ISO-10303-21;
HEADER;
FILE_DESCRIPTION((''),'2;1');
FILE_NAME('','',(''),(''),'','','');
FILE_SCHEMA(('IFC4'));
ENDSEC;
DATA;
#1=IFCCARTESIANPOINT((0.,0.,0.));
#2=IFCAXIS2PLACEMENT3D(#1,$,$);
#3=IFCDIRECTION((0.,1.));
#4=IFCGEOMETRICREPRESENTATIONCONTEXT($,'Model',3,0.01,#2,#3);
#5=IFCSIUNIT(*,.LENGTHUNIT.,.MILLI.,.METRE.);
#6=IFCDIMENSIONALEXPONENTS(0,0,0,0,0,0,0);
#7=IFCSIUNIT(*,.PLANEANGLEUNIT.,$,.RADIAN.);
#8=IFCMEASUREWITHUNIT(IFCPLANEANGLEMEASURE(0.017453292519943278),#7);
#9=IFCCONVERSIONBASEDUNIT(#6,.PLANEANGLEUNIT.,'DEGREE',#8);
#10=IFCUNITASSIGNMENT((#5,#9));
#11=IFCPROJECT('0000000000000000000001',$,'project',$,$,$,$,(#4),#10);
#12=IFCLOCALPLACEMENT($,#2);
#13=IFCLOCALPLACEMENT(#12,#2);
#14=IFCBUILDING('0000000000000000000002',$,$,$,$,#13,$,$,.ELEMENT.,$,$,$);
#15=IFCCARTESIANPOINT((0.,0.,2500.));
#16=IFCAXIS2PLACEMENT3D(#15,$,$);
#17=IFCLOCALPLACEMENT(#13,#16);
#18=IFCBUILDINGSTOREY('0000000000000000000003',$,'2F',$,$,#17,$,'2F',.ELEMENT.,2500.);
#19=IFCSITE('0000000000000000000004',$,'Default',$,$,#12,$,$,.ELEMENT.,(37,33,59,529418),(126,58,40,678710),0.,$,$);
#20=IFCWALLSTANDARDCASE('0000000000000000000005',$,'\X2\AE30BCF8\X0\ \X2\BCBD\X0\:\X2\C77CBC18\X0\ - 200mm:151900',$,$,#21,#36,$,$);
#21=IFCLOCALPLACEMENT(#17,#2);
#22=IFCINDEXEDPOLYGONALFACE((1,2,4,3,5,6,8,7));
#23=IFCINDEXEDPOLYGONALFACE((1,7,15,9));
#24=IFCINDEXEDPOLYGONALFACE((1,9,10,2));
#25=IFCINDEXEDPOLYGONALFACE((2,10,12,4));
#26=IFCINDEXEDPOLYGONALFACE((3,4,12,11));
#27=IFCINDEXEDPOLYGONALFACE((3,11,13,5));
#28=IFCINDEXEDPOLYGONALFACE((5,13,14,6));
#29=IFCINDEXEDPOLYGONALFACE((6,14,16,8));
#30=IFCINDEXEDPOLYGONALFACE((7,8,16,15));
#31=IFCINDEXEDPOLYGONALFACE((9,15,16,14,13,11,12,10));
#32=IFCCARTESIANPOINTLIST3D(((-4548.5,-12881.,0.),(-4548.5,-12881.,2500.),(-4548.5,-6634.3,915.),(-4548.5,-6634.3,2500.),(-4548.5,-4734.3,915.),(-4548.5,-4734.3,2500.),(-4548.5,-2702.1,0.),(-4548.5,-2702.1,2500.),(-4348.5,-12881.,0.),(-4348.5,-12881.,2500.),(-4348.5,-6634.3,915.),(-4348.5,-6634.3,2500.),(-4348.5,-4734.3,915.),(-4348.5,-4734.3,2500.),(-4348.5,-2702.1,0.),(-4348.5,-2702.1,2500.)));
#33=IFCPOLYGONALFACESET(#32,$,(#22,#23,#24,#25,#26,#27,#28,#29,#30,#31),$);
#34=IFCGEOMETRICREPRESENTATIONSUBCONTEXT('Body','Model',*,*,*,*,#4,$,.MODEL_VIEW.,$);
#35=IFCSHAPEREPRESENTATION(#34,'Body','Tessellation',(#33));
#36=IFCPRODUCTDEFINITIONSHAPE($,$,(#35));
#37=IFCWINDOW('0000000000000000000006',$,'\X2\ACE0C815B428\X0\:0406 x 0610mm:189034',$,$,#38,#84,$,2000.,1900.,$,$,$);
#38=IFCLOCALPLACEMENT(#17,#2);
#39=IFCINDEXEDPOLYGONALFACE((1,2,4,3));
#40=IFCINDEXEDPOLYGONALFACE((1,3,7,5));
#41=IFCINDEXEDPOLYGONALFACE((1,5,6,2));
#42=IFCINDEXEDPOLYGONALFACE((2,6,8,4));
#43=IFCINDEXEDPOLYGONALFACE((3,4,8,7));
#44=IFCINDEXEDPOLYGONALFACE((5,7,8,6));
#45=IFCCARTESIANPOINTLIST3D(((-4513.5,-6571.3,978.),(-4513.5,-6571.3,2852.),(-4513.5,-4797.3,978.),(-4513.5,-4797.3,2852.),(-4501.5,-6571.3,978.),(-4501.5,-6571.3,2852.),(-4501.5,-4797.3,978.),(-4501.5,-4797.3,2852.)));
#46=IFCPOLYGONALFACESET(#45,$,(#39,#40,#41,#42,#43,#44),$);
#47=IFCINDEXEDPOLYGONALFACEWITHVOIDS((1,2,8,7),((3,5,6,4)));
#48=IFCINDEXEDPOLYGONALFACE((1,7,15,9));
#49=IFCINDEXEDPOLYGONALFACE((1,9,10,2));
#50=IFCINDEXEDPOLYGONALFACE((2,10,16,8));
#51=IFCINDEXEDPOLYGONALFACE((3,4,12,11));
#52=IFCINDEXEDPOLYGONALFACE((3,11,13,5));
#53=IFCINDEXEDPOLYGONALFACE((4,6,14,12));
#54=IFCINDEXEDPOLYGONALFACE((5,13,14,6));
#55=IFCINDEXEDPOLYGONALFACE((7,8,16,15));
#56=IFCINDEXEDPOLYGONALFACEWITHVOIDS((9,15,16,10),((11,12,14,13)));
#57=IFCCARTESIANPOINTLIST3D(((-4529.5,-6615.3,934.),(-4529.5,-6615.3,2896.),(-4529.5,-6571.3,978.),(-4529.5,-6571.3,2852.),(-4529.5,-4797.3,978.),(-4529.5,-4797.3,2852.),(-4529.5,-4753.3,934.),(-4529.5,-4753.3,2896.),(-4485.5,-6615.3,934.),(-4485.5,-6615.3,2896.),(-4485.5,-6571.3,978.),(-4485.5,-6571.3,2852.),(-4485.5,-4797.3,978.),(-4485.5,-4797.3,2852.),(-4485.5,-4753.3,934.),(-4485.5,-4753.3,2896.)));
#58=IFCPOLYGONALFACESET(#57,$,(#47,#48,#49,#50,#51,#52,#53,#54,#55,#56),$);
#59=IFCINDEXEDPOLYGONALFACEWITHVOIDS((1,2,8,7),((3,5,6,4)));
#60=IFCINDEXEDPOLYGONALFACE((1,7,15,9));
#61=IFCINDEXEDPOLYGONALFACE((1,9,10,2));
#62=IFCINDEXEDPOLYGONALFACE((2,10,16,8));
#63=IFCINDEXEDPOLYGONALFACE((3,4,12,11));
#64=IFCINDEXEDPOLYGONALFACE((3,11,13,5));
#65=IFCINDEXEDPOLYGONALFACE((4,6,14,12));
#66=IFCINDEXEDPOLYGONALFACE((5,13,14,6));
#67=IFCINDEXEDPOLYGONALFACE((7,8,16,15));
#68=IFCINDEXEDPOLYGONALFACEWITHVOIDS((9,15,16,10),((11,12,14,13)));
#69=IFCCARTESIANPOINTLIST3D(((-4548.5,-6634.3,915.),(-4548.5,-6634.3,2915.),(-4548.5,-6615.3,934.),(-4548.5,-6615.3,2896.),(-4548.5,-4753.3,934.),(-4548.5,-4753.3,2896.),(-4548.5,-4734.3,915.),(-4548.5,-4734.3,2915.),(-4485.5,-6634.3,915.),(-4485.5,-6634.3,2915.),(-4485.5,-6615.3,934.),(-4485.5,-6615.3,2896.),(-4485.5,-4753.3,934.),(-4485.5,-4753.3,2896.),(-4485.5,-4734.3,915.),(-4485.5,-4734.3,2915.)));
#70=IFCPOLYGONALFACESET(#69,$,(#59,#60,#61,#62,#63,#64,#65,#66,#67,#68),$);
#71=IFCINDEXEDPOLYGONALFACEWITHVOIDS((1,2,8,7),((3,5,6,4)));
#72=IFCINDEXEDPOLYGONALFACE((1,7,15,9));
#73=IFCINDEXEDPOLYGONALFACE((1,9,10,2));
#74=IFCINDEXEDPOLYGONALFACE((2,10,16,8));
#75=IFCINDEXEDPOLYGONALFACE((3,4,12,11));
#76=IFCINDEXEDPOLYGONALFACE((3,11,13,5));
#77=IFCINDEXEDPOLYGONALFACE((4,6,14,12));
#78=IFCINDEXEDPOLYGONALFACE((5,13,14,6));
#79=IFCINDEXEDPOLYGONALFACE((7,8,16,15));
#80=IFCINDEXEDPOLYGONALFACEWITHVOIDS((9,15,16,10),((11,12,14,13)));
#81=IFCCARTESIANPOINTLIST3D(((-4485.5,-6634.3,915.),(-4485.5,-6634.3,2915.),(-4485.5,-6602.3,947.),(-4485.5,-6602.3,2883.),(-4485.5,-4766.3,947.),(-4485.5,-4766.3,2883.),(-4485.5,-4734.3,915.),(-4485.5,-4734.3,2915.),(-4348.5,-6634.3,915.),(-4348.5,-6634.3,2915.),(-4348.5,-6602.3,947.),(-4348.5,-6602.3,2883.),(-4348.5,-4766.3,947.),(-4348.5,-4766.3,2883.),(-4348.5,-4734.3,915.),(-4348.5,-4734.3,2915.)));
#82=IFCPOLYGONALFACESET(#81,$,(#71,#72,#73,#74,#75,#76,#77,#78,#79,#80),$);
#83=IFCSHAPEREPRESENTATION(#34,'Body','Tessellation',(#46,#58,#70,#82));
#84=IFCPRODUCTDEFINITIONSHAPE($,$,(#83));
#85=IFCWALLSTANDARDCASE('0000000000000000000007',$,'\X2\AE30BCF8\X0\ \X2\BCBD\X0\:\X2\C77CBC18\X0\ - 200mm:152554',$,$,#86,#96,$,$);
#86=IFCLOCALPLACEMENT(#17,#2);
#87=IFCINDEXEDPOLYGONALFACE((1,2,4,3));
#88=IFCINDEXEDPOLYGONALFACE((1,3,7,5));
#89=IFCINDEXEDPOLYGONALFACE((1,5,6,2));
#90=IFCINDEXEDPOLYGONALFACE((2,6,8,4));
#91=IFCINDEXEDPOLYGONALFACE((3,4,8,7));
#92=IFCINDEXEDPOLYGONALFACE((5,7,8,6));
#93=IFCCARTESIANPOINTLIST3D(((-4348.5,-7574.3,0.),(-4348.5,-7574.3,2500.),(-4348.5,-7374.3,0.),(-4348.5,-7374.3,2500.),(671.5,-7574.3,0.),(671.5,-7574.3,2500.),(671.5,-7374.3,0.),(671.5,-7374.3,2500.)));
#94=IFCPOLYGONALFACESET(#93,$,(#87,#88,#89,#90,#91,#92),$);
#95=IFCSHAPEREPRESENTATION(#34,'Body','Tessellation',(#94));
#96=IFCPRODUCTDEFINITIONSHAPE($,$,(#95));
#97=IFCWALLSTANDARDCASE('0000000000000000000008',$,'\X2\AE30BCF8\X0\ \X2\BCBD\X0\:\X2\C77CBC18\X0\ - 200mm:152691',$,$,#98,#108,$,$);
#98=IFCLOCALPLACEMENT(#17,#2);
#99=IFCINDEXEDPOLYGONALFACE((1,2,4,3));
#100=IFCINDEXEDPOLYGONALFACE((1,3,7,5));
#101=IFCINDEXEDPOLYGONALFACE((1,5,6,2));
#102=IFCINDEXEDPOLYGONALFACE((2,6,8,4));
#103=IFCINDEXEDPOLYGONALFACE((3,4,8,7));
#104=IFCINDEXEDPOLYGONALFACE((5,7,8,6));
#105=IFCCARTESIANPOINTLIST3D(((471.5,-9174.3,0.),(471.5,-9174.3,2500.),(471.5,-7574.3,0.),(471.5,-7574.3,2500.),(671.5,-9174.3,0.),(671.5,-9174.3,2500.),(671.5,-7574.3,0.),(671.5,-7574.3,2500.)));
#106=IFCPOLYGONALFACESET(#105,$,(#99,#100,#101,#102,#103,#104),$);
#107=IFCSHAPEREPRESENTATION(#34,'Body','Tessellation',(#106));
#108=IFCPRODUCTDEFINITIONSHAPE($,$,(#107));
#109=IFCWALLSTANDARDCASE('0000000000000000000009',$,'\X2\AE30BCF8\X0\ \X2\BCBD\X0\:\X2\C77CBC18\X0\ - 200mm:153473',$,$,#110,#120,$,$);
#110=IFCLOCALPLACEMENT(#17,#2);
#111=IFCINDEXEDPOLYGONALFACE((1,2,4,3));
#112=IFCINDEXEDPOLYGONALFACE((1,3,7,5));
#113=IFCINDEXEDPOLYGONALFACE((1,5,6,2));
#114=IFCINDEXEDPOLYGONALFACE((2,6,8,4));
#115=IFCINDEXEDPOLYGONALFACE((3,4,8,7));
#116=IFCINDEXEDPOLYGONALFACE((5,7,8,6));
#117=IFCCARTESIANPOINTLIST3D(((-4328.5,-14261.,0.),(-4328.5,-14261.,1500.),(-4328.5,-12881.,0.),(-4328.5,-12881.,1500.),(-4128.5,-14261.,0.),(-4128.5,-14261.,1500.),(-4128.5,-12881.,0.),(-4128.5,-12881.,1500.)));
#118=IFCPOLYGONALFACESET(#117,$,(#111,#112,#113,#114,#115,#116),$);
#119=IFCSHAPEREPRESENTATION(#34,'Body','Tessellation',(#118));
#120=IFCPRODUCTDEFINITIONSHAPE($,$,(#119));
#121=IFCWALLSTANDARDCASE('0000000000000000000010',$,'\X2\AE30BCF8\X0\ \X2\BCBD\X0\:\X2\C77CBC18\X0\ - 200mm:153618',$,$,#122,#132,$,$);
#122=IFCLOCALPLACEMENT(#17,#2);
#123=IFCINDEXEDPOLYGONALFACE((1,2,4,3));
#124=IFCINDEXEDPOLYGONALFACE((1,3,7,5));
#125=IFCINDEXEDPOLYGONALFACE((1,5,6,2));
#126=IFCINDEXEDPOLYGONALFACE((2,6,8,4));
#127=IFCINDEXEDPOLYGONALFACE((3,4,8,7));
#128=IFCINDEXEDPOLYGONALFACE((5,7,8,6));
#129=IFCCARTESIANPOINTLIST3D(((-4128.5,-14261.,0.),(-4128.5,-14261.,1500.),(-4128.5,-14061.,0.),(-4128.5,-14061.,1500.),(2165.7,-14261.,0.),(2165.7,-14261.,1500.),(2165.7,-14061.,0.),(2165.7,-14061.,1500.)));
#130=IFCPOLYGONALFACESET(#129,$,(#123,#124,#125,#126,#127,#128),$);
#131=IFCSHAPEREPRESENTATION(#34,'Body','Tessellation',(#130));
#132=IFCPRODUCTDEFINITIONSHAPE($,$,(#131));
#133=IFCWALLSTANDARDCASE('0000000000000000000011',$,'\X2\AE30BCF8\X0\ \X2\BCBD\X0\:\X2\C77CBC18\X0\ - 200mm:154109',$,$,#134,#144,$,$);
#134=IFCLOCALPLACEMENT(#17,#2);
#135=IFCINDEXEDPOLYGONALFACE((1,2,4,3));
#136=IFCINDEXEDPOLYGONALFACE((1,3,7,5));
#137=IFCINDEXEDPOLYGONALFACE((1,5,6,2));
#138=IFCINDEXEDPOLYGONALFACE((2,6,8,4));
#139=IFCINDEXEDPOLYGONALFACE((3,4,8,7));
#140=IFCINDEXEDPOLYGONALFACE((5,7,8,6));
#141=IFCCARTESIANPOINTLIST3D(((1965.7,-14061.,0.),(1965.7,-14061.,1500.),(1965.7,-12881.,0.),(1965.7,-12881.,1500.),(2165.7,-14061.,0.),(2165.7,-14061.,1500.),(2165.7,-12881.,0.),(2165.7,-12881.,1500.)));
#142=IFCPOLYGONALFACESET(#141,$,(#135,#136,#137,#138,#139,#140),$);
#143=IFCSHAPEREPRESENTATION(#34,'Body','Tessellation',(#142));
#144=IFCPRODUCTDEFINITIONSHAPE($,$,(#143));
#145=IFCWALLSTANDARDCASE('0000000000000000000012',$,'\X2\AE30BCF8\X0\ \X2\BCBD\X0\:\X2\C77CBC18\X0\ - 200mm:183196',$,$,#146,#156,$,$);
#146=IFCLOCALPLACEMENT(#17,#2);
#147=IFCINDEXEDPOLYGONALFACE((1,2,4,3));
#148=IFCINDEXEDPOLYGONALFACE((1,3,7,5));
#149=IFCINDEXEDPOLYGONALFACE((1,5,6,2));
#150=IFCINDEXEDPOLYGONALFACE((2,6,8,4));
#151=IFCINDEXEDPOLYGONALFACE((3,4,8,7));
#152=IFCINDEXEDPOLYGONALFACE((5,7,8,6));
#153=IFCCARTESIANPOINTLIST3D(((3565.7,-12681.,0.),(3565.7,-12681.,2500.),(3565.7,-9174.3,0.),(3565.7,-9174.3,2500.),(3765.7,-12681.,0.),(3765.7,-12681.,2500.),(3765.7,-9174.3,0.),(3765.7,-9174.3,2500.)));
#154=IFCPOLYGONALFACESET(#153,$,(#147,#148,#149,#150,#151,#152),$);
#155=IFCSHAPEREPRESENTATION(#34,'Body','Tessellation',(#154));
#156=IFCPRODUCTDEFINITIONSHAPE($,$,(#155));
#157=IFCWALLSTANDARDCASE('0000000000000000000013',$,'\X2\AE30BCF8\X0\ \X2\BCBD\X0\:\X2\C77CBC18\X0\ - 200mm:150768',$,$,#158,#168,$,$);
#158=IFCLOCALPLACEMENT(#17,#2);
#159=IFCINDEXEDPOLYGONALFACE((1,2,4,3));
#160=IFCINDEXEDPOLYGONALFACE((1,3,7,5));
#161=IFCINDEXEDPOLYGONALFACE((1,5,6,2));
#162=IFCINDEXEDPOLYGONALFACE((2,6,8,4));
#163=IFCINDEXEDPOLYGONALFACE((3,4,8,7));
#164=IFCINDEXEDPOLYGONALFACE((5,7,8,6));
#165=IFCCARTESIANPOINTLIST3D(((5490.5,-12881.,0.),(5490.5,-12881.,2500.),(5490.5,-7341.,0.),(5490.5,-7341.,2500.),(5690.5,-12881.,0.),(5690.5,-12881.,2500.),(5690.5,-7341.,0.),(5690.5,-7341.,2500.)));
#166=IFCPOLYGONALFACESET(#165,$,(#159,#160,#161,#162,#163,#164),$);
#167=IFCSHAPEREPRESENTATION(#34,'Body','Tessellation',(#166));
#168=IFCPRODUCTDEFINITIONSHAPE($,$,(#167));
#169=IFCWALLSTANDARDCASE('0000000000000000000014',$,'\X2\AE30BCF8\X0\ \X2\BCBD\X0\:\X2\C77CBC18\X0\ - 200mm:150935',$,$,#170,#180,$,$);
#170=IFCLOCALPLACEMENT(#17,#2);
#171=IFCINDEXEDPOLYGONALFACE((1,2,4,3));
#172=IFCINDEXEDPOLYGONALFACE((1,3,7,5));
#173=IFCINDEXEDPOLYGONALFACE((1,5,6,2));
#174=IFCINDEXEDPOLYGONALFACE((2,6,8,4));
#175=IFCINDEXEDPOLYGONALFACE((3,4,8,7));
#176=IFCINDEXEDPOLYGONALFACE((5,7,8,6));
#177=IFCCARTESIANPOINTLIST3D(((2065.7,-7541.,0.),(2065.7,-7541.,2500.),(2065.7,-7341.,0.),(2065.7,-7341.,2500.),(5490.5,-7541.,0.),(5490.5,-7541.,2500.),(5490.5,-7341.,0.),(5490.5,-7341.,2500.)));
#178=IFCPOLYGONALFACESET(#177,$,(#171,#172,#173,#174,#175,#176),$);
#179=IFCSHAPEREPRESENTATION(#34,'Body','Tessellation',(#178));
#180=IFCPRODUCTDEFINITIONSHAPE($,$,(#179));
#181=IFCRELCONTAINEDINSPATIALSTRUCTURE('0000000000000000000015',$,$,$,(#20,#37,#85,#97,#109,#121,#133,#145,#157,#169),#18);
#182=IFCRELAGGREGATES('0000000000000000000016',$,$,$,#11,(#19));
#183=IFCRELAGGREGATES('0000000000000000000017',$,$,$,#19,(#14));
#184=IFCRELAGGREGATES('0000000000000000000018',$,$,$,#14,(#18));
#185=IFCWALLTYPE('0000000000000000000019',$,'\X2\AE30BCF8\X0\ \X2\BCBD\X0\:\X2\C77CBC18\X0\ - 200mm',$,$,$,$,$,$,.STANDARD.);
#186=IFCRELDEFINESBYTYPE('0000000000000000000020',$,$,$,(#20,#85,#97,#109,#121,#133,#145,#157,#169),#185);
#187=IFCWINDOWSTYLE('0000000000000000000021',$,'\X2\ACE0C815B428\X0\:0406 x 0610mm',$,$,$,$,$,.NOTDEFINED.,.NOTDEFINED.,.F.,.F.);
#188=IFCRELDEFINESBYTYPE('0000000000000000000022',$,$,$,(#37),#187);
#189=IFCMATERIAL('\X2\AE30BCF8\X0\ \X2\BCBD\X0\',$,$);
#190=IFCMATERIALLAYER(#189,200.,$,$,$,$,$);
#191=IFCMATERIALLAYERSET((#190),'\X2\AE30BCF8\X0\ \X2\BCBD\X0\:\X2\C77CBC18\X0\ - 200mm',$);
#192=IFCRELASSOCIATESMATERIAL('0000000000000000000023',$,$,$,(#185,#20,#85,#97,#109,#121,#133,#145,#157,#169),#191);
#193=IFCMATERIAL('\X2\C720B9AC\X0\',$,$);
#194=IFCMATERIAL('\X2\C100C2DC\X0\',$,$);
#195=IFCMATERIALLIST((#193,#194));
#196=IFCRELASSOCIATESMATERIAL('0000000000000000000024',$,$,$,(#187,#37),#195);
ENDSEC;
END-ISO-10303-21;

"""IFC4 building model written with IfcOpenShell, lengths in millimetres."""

from ifc_helpers import new_model, entity, si_unit, converted_unit, direction, frame, frame_2d, origin, place, context, subcontext, project, spatial, polyline, rectangle, outline, extrude, source, transform, mapped, material, material_list, layer, layer_set, layer_usage, type_object, type_shapes, element, fill, save


model = new_model("IFC4")

# Units and contexts
model_context = context("Model", 3, precision=0.01, world=origin(), true_north=direction((0.0, 1.0)))
body_context = subcontext(model_context, "Body", "Model", "MODEL_VIEW")
ifc_project = project(units=[si_unit("LENGTHUNIT", "METRE", prefix="MILLI"), converted_unit("PLANEANGLEUNIT", "DEGREE", entity("IfcPlaneAngleMeasure", 0.017453292519943278), si_unit("PLANEANGLEUNIT", "RADIAN"), dimensions=[0, 0, 0, 0, 0, 0, 0])], contexts=[model_context])

# Site, building, storey
site_placement = place(None, origin())
site = spatial("IfcSite", under=ifc_project, at=site_placement, Name="Default", CompositionType="ELEMENT", RefLatitude=(37, 33, 59, 529418), RefLongitude=(126, 58, 40, 678710), RefElevation=0.0)
building_placement = place(site_placement, origin())
building = spatial("IfcBuilding", under=site, at=building_placement, CompositionType="ELEMENT")
storey_placement = place(building_placement, frame((0.0, 0.0, 2500.0)))
storey = spatial("IfcBuildingStorey", under=building, at=storey_placement, Name="2F", LongName="2F", CompositionType="ELEMENT", Elevation=2500.0)

# Shared definitions
ifc_material_1 = material(Name="기본 벽")
ifc_layer_1 = layer(ifc_material_1, 200.0)
ifc_layer_set_1 = layer_set([ifc_layer_1], Name="기본 벽:일반 - 200mm")
wall_type = type_object("IfcWallType", Name="기본 벽:일반 - 200mm", PredefinedType="STANDARD", material=ifc_layer_set_1)

# Shared definitions
ifc_material_2 = material(Name="유리")
ifc_material_3 = material(Name="섀시")
ifc_material_list_1 = material_list([ifc_material_2, ifc_material_3])
window_style = type_object("IfcWindowStyle", Name="고정됨:0406 x 0610mm", ConstructionType="NOTDEFINED", OperationType="NOTDEFINED", ParameterTakesPrecedence=False, Sizeable=False, material=ifc_material_list_1)
shared_shape_1 = source(origin(), body_context, "Body", "SweptSolid", [
    extrude(rectangle(XDim=12.0, YDim=1774.0, at=frame_2d((0.0, 0.0), x_axis=(1.0, 0.0))), frame((950.0, 159.0, 63.0), z_axis=(0.0, 0.0, 1.0), x_axis=(0.0, -1.0, 0.0)), (0.0, 0.0, 1.0), 1874.0),
    extrude(outline(polyline([(-931.0, -981.0), (931.0, -981.0), (931.0, 981.0), (-931.0, 981.0), (-931.0, -981.0)]), holes=[polyline([(-887.0, -937.0), (-887.0, 937.0), (887.0, 937.0), (887.0, -937.0), (-887.0, -937.0)])]), frame((950.0, 137.0, 1000.0), z_axis=(0.0, 1.0, 0.0), x_axis=(1.0, 0.0, 0.0)), (0.0, 0.0, 1.0), 44.0),
    extrude(outline(polyline([(-950.0, -1000.0), (950.0, -1000.0), (950.0, 1000.0), (-950.0, 1000.0), (-950.0, -1000.0)]), holes=[polyline([(-931.0, -981.0), (-931.0, 981.0), (931.0, 981.0), (931.0, -981.0), (-931.0, -981.0)])]), frame((950.0, 137.0, 1000.0), z_axis=(0.0, 1.0, 0.0), x_axis=(1.0, 0.0, 0.0)), (0.0, 0.0, 1.0), 63.0),
    extrude(outline(polyline([(-950.0, -1000.0), (950.0, -1000.0), (950.0, 1000.0), (-950.0, 1000.0), (-950.0, -1000.0)]), holes=[polyline([(-918.0, -968.0), (-918.0, 968.0), (918.0, 968.0), (918.0, -968.0), (-918.0, -968.0)])]), frame((950.0, 0.0, 1000.0), z_axis=(0.0, 1.0, 0.0), x_axis=(1.0, 0.0, 0.0)), (0.0, 0.0, 1.0), 137.0),
])
type_shapes(window_style, [shared_shape_1])

# Wall, opening, window
ifc_layer_usage_1 = layer_usage(ifc_layer_set_1, "AXIS2", "NEGATIVE", 100.0)
wall_1_placement = place(storey_placement, frame((-4448.5, -12881.0, 0.0), z_axis=(0.0, 0.0, 1.0), x_axis=(0.0, 1.0, 0.0)))
wall_1 = element("IfcWallStandardCase", 1, at=wall_1_placement, inside=storey, type_object=wall_type, material=ifc_layer_usage_1, Name="기본 벽:일반 - 200mm:151900", context=body_context, shape_type="SweptSolid", body=[
    extrude(rectangle(XDim=10178.9, YDim=200.0, at=frame_2d((5089.4, 0.0), x_axis=(-1.0, 0.0))), origin(), (0.0, 0.0, 1.0), 2500.0),
])
opening_1_placement = place(wall_1_placement, frame((6246.6, -100.0, 915.0)))
opening_1 = element("IfcOpeningElement", 2, at=opening_1_placement, cuts=wall_1, ObjectType="Opening", context=body_context, shape_type="SweptSolid", body=[
    extrude(rectangle(XDim=2000.0, YDim=1900.0, at=frame_2d((1000.0, 950.0), x_axis=(1.0, 0.0))), frame((0.0, 0.0, 0.0), z_axis=(0.0, 1.0, 0.0), x_axis=(0.0, 0.0, 1.0)), (0.0, 0.0, 1.0), 200.0),
])
window_1_placement = place(opening_1_placement, origin())
window_1 = element("IfcWindow", 3, at=window_1_placement, inside=storey, type_object=window_style, material=ifc_material_list_1, Name="고정됨:0406 x 0610mm:189034", OverallHeight=2000.0, OverallWidth=1900.0, context=body_context, shape_type="MappedRepresentation", body=[
    mapped(shared_shape_1, transform((0.0, 0.0, 0.0), scale=1.0)),
])
fill(opening_1, window_1)

# Walls
ifc_layer_usage_2 = layer_usage(ifc_layer_set_1, "AXIS2", "NEGATIVE", 100.0)
wall_2_placement = place(storey_placement, frame((-4348.5, -7474.3, 0.0)))
element("IfcWallStandardCase", 4, at=wall_2_placement, inside=storey, type_object=wall_type, material=ifc_layer_usage_2, Name="기본 벽:일반 - 200mm:152554", context=body_context, shape_type="SweptSolid", body=[
    extrude(rectangle(XDim=5020.0, YDim=200.0, at=frame_2d((2510.0, 0.0), x_axis=(-1.0, 0.0))), origin(), (0.0, 0.0, 1.0), 2500.0),
])
ifc_layer_usage_3 = layer_usage(ifc_layer_set_1, "AXIS2", "NEGATIVE", 100.0)
wall_3_placement = place(storey_placement, frame((571.5, -7574.3, 0.0), z_axis=(0.0, 0.0, 1.0), x_axis=(0.0, -1.0, 0.0)))
element("IfcWallStandardCase", 5, at=wall_3_placement, inside=storey, type_object=wall_type, material=ifc_layer_usage_3, Name="기본 벽:일반 - 200mm:152691", context=body_context, shape_type="SweptSolid", body=[
    extrude(rectangle(XDim=1600.0, YDim=200.0, at=frame_2d((800.0, 0.0), x_axis=(-1.0, 0.0))), origin(), (0.0, 0.0, 1.0), 2500.0),
])
ifc_layer_usage_4 = layer_usage(ifc_layer_set_1, "AXIS2", "NEGATIVE", 100.0)
wall_4_placement = place(storey_placement, frame((-4228.5, -12881.0, 0.0), z_axis=(0.0, 0.0, 1.0), x_axis=(0.0, -1.0, 0.0)))
element("IfcWallStandardCase", 6, at=wall_4_placement, inside=storey, type_object=wall_type, material=ifc_layer_usage_4, Name="기본 벽:일반 - 200mm:153473", context=body_context, shape_type="SweptSolid", body=[
    extrude(rectangle(XDim=1380.0, YDim=200.0, at=frame_2d((690.0, 0.0), x_axis=(-1.0, 0.0))), origin(), (0.0, 0.0, 1.0), 1500.0),
])
ifc_layer_usage_5 = layer_usage(ifc_layer_set_1, "AXIS2", "NEGATIVE", 100.0)
wall_5_placement = place(storey_placement, frame((-4128.5, -14161.0, 0.0)))
element("IfcWallStandardCase", 7, at=wall_5_placement, inside=storey, type_object=wall_type, material=ifc_layer_usage_5, Name="기본 벽:일반 - 200mm:153618", context=body_context, shape_type="SweptSolid", body=[
    extrude(rectangle(XDim=6294.2, YDim=200.0, at=frame_2d((3147.1, 0.0), x_axis=(-1.0, 0.0))), origin(), (0.0, 0.0, 1.0), 1500.0),
])
ifc_layer_usage_6 = layer_usage(ifc_layer_set_1, "AXIS2", "NEGATIVE", 100.0)
wall_6_placement = place(storey_placement, frame((2065.7, -14061.0, 0.0), z_axis=(0.0, 0.0, 1.0), x_axis=(0.0, 1.0, 0.0)))
element("IfcWallStandardCase", 8, at=wall_6_placement, inside=storey, type_object=wall_type, material=ifc_layer_usage_6, Name="기본 벽:일반 - 200mm:154109", context=body_context, shape_type="SweptSolid", body=[
    extrude(rectangle(XDim=1180.0, YDim=200.0, at=frame_2d((590.0, 0.0), x_axis=(-1.0, 0.0))), origin(), (0.0, 0.0, 1.0), 1500.0),
])
ifc_layer_usage_7 = layer_usage(ifc_layer_set_1, "AXIS2", "NEGATIVE", 100.0)
wall_7_placement = place(storey_placement, frame((3665.7, -9174.3, 0.0), z_axis=(0.0, 0.0, 1.0), x_axis=(0.0, -1.0, 0.0)))
element("IfcWallStandardCase", 9, at=wall_7_placement, inside=storey, type_object=wall_type, material=ifc_layer_usage_7, Name="기본 벽:일반 - 200mm:183196", context=body_context, shape_type="SweptSolid", body=[
    extrude(rectangle(XDim=3506.6, YDim=200.0, at=frame_2d((1753.3, 0.0), x_axis=(-1.0, 0.0))), origin(), (0.0, 0.0, 1.0), 2500.0),
])
ifc_layer_usage_8 = layer_usage(ifc_layer_set_1, "AXIS2", "NEGATIVE", 100.0)
wall_8_placement = place(storey_placement, frame((5590.5, -12881.0, 0.0), z_axis=(0.0, 0.0, 1.0), x_axis=(0.0, 1.0, 0.0)))
element("IfcWallStandardCase", 10, at=wall_8_placement, inside=storey, type_object=wall_type, material=ifc_layer_usage_8, Name="기본 벽:일반 - 200mm:150768", context=body_context, shape_type="SweptSolid", body=[
    extrude(rectangle(XDim=5540.0, YDim=200.0, at=frame_2d((2770.0, 0.0), x_axis=(-1.0, 0.0))), origin(), (0.0, 0.0, 1.0), 2500.0),
])
ifc_layer_usage_9 = layer_usage(ifc_layer_set_1, "AXIS2", "NEGATIVE", 100.0)
wall_9_placement = place(storey_placement, frame((5490.5, -7441.0, 0.0), z_axis=(0.0, 0.0, 1.0), x_axis=(-1.0, 0.0, 0.0)))
element("IfcWallStandardCase", 11, at=wall_9_placement, inside=storey, type_object=wall_type, material=ifc_layer_usage_9, Name="기본 벽:일반 - 200mm:150935", context=body_context, shape_type="SweptSolid", body=[
    extrude(rectangle(XDim=3424.8, YDim=200.0, at=frame_2d((1712.4, 0.0), x_axis=(-1.0, 0.0))), origin(), (0.0, 0.0, 1.0), 2500.0),
])

save(model, "model.ifc")
